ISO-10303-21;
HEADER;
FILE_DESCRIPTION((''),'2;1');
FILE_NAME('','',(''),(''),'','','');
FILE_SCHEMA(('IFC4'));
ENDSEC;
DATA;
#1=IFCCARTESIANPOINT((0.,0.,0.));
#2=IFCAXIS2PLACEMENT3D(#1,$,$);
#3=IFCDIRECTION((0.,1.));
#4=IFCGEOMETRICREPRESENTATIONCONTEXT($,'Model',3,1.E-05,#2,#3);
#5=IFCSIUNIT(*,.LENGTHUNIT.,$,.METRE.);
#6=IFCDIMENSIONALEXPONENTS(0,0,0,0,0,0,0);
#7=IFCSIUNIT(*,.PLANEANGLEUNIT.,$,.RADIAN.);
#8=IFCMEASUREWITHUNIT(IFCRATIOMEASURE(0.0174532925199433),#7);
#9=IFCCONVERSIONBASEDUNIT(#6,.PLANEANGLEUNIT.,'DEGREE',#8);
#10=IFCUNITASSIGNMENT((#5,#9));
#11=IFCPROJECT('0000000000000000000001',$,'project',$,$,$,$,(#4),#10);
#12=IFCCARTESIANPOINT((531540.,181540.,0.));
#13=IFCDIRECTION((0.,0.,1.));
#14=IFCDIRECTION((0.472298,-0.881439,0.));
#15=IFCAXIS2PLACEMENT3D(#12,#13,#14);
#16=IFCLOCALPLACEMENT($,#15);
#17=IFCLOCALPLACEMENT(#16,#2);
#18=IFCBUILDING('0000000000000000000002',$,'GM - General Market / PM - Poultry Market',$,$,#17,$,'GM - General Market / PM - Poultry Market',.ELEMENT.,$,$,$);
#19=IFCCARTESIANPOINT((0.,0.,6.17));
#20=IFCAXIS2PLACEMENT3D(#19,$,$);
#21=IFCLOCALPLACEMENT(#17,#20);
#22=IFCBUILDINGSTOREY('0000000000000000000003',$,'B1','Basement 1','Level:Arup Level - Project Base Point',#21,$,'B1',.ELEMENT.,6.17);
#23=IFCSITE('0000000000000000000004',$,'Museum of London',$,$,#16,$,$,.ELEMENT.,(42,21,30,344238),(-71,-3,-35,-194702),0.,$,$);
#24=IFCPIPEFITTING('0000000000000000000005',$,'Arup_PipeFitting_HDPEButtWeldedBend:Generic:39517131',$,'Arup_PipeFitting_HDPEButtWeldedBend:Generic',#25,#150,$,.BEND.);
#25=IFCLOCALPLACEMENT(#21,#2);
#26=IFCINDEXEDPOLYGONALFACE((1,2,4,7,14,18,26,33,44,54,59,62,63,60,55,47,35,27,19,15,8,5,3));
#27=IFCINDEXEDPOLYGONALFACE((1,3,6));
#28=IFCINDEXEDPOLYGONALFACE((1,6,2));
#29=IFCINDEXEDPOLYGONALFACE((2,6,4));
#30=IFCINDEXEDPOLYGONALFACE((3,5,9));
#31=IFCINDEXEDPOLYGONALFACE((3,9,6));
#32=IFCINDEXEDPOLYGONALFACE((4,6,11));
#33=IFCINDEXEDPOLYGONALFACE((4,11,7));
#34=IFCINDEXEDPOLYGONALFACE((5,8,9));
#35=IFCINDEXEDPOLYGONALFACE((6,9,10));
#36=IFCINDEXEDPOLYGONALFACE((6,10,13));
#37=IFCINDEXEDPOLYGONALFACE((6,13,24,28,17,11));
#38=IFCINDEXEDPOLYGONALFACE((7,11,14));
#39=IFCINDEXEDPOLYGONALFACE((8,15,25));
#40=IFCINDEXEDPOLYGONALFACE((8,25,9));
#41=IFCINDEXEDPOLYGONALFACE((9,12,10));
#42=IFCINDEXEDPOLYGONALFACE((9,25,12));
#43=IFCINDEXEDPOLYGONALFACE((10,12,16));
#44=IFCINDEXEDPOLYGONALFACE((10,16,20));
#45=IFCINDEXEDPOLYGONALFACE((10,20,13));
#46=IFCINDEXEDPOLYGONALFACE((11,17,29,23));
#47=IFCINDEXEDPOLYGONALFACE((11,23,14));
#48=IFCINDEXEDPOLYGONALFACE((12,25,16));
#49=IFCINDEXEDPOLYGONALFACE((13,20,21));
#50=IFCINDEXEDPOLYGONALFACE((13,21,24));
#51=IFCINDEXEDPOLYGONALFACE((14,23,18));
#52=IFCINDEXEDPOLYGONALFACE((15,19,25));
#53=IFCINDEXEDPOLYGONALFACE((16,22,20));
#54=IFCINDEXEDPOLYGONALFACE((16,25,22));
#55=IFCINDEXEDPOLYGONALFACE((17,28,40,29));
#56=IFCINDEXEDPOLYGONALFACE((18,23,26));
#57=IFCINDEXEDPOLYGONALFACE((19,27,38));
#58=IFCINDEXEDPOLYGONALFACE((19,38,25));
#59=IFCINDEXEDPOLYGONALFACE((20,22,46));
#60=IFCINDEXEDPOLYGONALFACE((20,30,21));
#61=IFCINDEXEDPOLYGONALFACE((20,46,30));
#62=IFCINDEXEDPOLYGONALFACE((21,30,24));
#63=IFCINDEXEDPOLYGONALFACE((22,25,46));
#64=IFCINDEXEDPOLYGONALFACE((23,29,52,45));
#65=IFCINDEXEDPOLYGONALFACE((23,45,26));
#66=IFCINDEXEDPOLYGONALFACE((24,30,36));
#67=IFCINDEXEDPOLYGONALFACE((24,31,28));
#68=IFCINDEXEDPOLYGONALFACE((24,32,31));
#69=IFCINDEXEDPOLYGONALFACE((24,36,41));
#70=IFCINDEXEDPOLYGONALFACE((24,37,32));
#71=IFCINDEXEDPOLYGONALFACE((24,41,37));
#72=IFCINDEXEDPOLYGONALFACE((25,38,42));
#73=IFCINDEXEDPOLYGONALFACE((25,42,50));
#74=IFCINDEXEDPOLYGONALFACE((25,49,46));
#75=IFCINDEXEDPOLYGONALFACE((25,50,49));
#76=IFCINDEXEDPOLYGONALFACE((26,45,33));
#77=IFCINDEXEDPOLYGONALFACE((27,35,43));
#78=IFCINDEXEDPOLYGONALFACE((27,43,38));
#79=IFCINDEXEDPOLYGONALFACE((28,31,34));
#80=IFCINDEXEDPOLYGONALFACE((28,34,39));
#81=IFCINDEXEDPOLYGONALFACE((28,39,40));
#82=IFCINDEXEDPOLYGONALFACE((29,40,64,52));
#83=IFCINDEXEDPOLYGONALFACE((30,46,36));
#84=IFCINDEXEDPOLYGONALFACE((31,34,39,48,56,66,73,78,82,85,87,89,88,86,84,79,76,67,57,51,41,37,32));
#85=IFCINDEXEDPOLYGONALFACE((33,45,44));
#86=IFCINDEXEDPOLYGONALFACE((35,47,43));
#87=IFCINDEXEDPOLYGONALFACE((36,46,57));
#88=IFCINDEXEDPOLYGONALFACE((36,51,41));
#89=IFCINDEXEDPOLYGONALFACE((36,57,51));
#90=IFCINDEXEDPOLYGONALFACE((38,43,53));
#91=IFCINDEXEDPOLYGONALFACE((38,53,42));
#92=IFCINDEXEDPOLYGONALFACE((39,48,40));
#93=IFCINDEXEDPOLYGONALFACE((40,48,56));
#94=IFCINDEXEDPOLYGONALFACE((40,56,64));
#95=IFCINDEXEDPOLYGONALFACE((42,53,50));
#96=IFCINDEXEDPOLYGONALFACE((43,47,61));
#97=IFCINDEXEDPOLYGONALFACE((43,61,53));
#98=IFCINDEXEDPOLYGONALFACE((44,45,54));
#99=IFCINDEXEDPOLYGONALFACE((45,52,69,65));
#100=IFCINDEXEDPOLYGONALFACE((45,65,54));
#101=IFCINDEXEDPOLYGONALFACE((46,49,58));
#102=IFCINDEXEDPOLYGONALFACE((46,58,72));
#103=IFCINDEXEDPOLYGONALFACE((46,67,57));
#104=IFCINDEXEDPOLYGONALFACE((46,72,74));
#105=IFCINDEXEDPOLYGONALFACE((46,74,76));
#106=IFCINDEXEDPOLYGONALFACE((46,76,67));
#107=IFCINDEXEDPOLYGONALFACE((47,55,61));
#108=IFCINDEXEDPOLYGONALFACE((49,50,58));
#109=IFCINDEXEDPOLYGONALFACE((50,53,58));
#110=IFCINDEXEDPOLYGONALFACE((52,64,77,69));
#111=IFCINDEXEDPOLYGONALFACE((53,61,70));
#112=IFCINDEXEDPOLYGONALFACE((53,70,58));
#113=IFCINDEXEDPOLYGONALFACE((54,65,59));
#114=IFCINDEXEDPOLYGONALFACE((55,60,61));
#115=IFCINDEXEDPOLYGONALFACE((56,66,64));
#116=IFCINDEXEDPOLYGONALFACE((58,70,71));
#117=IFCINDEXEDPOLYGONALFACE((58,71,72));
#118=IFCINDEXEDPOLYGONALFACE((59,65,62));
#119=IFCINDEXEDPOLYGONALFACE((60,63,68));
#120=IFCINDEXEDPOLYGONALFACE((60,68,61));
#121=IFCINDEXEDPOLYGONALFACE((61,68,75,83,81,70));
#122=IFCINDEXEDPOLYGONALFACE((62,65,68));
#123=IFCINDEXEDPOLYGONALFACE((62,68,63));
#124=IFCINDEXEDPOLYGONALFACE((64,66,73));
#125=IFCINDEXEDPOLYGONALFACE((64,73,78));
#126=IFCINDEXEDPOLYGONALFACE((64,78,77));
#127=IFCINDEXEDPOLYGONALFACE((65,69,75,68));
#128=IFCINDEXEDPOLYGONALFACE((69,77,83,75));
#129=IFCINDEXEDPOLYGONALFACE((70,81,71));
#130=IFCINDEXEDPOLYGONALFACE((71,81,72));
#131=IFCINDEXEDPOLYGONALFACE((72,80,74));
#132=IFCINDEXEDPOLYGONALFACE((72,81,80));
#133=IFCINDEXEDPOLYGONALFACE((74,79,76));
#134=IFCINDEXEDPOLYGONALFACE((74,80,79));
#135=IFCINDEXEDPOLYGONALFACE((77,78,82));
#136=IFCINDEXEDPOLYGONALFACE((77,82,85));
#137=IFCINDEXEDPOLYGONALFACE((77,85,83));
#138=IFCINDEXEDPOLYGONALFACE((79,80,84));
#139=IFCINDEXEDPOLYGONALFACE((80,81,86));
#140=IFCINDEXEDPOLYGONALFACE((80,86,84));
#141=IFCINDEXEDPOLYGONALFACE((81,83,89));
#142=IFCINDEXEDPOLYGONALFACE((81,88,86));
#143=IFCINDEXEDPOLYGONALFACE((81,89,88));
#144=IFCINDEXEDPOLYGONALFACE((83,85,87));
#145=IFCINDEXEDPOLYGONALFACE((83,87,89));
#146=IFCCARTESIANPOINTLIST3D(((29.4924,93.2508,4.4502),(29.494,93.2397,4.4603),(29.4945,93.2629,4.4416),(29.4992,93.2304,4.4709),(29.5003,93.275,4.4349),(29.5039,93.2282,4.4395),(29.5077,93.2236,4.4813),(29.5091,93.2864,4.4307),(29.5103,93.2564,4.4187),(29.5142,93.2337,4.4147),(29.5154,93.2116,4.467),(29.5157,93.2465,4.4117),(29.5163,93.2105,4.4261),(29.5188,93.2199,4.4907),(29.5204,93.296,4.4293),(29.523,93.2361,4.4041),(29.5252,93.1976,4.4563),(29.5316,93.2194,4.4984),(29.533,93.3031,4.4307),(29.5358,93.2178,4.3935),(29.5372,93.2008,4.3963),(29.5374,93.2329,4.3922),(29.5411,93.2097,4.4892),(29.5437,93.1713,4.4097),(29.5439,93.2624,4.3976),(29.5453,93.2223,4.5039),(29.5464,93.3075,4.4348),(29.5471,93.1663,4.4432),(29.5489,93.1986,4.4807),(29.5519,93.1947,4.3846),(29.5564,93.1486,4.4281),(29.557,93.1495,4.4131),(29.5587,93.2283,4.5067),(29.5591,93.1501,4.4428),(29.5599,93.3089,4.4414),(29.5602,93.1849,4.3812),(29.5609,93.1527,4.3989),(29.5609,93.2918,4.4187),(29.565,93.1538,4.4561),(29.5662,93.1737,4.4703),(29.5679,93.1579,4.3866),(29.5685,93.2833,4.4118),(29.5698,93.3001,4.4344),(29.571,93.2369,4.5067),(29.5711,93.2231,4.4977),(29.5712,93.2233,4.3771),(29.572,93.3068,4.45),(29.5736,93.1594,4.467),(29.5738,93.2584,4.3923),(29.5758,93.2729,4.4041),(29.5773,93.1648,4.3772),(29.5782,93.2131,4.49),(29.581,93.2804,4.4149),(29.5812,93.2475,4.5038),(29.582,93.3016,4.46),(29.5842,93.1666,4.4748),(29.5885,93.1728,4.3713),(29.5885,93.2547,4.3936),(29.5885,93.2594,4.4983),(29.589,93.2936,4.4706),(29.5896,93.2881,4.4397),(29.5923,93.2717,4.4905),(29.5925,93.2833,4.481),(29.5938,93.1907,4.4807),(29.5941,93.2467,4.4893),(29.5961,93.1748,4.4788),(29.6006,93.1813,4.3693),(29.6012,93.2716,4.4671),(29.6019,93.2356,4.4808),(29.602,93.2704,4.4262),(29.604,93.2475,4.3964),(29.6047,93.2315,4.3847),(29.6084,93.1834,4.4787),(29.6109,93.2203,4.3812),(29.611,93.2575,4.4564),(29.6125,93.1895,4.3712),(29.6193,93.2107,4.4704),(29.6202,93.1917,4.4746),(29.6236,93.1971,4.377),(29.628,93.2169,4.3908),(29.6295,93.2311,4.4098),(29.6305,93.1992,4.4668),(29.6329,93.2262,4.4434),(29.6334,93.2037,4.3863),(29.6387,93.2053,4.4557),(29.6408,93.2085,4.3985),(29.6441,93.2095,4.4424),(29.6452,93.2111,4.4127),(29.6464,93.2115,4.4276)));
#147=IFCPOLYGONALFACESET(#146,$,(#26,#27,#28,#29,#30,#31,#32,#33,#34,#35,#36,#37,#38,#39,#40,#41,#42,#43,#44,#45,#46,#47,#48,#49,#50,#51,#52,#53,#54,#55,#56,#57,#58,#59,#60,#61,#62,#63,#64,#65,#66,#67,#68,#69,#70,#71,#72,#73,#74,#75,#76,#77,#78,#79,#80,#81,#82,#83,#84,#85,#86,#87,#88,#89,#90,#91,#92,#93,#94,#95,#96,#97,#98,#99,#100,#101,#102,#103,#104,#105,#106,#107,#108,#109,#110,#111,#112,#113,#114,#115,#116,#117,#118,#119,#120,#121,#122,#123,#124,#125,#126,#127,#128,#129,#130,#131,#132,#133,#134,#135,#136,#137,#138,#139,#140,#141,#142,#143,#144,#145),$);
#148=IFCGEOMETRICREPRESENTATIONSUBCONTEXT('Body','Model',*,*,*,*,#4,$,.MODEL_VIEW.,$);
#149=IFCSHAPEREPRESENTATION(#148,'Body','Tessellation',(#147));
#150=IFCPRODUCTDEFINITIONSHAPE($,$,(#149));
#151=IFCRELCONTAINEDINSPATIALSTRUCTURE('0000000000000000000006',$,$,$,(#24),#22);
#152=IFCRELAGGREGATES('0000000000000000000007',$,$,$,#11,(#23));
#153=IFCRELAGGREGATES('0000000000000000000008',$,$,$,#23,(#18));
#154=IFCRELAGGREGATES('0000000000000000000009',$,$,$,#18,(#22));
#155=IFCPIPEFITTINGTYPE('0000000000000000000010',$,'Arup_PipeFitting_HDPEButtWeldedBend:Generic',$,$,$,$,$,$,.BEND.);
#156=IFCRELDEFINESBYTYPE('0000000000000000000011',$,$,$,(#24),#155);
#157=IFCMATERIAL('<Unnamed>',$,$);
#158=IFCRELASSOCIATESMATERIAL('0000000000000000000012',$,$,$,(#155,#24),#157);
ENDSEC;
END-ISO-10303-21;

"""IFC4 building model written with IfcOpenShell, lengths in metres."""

from ifc_helpers import new_model, entity, si_unit, converted_unit, direction, frame, origin, place, context, subcontext, project, spatial, source, transform, mapped, material, type_object, type_shapes, element, save


model = new_model("IFC4")

# Units and contexts
model_context = context("Model", 3, precision=1e-05, world=origin(), true_north=direction((0.0, 1.0)))
body_context = subcontext(model_context, "Body", "Model", "MODEL_VIEW")
ifc_project = project(units=[si_unit("LENGTHUNIT", "METRE"), converted_unit("PLANEANGLEUNIT", "DEGREE", entity("IfcRatioMeasure", 0.0174532925199433), si_unit("PLANEANGLEUNIT", "RADIAN"), dimensions=[0, 0, 0, 0, 0, 0, 0])], contexts=[model_context])

# Site, building, storey
site_placement = place(None, frame((531540.0, 181540.0, 0.0), z_axis=(0.0, 0.0, 1.0), x_axis=(0.472298, -0.881439, 0.0)))
site = spatial("IfcSite", under=ifc_project, at=site_placement, Name="Museum of London", CompositionType="ELEMENT", RefLatitude=(42, 21, 30, 344238), RefLongitude=(-71, -3, -35, -194702), RefElevation=0.0)
building_placement = place(site_placement, origin())
building = spatial("IfcBuilding", under=site, at=building_placement, Name="GM - General Market / PM - Poultry Market", LongName="GM - General Market / PM - Poultry Market", CompositionType="ELEMENT")
storey_placement = place(building_placement, frame((0.0, 0.0, 6.17)))
storey = spatial("IfcBuildingStorey", under=building, at=storey_placement, Name="B1", Description="Basement 1", ObjectType="Level:Arup Level - Project Base Point", LongName="B1", CompositionType="ELEMENT", Elevation=6.17)

# Shared definitions
ifc_material_1 = material(Name="<Unnamed>")

# Pipe fitting
pipe_fitting_type_1 = type_object("IfcPipeFittingType", Name="Arup_PipeFitting_HDPEButtWeldedBend:Generic", PredefinedType="BEND", material=ifc_material_1)
ifc_direction_1 = entity("IfcDirection", [0.0, 0.0, 1.0])
trimmed_curve_1 = entity("IfcTrimmedCurve", entity("IfcCircle", entity("IfcAxis2Placement2D", entity("IfcCartesianPoint", [-0.1502, 0.0]), entity("IfcDirection", [0.0, 1.0])), 0.1502), [entity("IfcParameterValue", 270.0)], [entity("IfcParameterValue", 313.561244)], True, "PARAMETER")
shared_shape_1 = source(origin(), body_context, "Body", "AdvancedSweptSolid", [
    entity("IfcSurfaceCurveSweptAreaSolid", entity("IfcCircleProfileDef", "AREA", None, entity("IfcAxis2Placement2D", entity("IfcCartesianPoint", [0.0, 0.0]), entity("IfcDirection", [1.0, 0.0])), 0.055), entity("IfcAxis2Placement3D", entity("IfcCartesianPoint", [-0.06, 0.0, 0.0]), ifc_direction_1, entity("IfcDirection", [0.0, -1.0, 0.0])), trimmed_curve_1, 0.0, 43.5612, entity("IfcSurfaceOfLinearExtrusion", entity("IfcArbitraryOpenProfileDef", "CURVE", None, trimmed_curve_1), entity("IfcAxis2Placement3D", entity("IfcCartesianPoint", [0.0, 0.0, -0.3048])), ifc_direction_1, 1.0)),
])
type_shapes(pipe_fitting_type_1, [shared_shape_1])
pipe_fitting_1_placement = place(storey_placement, frame((29.567, 93.2293, 4.4258), z_axis=(0.819885, 0.572526, 0.001418), x_axis=(-0.572376, 0.819607, 0.025109)))
element("IfcPipeFitting", 1, at=pipe_fitting_1_placement, inside=storey, type_object=pipe_fitting_type_1, material=ifc_material_1, Name="Arup_PipeFitting_HDPEButtWeldedBend:Generic:39517131", ObjectType="Arup_PipeFitting_HDPEButtWeldedBend:Generic", PredefinedType="BEND", context=body_context, shape_type="MappedRepresentation", body=[
    mapped(shared_shape_1, transform((0.0, 0.0, 0.0), scale=1.0)),
])

save(model, "model.ifc")
